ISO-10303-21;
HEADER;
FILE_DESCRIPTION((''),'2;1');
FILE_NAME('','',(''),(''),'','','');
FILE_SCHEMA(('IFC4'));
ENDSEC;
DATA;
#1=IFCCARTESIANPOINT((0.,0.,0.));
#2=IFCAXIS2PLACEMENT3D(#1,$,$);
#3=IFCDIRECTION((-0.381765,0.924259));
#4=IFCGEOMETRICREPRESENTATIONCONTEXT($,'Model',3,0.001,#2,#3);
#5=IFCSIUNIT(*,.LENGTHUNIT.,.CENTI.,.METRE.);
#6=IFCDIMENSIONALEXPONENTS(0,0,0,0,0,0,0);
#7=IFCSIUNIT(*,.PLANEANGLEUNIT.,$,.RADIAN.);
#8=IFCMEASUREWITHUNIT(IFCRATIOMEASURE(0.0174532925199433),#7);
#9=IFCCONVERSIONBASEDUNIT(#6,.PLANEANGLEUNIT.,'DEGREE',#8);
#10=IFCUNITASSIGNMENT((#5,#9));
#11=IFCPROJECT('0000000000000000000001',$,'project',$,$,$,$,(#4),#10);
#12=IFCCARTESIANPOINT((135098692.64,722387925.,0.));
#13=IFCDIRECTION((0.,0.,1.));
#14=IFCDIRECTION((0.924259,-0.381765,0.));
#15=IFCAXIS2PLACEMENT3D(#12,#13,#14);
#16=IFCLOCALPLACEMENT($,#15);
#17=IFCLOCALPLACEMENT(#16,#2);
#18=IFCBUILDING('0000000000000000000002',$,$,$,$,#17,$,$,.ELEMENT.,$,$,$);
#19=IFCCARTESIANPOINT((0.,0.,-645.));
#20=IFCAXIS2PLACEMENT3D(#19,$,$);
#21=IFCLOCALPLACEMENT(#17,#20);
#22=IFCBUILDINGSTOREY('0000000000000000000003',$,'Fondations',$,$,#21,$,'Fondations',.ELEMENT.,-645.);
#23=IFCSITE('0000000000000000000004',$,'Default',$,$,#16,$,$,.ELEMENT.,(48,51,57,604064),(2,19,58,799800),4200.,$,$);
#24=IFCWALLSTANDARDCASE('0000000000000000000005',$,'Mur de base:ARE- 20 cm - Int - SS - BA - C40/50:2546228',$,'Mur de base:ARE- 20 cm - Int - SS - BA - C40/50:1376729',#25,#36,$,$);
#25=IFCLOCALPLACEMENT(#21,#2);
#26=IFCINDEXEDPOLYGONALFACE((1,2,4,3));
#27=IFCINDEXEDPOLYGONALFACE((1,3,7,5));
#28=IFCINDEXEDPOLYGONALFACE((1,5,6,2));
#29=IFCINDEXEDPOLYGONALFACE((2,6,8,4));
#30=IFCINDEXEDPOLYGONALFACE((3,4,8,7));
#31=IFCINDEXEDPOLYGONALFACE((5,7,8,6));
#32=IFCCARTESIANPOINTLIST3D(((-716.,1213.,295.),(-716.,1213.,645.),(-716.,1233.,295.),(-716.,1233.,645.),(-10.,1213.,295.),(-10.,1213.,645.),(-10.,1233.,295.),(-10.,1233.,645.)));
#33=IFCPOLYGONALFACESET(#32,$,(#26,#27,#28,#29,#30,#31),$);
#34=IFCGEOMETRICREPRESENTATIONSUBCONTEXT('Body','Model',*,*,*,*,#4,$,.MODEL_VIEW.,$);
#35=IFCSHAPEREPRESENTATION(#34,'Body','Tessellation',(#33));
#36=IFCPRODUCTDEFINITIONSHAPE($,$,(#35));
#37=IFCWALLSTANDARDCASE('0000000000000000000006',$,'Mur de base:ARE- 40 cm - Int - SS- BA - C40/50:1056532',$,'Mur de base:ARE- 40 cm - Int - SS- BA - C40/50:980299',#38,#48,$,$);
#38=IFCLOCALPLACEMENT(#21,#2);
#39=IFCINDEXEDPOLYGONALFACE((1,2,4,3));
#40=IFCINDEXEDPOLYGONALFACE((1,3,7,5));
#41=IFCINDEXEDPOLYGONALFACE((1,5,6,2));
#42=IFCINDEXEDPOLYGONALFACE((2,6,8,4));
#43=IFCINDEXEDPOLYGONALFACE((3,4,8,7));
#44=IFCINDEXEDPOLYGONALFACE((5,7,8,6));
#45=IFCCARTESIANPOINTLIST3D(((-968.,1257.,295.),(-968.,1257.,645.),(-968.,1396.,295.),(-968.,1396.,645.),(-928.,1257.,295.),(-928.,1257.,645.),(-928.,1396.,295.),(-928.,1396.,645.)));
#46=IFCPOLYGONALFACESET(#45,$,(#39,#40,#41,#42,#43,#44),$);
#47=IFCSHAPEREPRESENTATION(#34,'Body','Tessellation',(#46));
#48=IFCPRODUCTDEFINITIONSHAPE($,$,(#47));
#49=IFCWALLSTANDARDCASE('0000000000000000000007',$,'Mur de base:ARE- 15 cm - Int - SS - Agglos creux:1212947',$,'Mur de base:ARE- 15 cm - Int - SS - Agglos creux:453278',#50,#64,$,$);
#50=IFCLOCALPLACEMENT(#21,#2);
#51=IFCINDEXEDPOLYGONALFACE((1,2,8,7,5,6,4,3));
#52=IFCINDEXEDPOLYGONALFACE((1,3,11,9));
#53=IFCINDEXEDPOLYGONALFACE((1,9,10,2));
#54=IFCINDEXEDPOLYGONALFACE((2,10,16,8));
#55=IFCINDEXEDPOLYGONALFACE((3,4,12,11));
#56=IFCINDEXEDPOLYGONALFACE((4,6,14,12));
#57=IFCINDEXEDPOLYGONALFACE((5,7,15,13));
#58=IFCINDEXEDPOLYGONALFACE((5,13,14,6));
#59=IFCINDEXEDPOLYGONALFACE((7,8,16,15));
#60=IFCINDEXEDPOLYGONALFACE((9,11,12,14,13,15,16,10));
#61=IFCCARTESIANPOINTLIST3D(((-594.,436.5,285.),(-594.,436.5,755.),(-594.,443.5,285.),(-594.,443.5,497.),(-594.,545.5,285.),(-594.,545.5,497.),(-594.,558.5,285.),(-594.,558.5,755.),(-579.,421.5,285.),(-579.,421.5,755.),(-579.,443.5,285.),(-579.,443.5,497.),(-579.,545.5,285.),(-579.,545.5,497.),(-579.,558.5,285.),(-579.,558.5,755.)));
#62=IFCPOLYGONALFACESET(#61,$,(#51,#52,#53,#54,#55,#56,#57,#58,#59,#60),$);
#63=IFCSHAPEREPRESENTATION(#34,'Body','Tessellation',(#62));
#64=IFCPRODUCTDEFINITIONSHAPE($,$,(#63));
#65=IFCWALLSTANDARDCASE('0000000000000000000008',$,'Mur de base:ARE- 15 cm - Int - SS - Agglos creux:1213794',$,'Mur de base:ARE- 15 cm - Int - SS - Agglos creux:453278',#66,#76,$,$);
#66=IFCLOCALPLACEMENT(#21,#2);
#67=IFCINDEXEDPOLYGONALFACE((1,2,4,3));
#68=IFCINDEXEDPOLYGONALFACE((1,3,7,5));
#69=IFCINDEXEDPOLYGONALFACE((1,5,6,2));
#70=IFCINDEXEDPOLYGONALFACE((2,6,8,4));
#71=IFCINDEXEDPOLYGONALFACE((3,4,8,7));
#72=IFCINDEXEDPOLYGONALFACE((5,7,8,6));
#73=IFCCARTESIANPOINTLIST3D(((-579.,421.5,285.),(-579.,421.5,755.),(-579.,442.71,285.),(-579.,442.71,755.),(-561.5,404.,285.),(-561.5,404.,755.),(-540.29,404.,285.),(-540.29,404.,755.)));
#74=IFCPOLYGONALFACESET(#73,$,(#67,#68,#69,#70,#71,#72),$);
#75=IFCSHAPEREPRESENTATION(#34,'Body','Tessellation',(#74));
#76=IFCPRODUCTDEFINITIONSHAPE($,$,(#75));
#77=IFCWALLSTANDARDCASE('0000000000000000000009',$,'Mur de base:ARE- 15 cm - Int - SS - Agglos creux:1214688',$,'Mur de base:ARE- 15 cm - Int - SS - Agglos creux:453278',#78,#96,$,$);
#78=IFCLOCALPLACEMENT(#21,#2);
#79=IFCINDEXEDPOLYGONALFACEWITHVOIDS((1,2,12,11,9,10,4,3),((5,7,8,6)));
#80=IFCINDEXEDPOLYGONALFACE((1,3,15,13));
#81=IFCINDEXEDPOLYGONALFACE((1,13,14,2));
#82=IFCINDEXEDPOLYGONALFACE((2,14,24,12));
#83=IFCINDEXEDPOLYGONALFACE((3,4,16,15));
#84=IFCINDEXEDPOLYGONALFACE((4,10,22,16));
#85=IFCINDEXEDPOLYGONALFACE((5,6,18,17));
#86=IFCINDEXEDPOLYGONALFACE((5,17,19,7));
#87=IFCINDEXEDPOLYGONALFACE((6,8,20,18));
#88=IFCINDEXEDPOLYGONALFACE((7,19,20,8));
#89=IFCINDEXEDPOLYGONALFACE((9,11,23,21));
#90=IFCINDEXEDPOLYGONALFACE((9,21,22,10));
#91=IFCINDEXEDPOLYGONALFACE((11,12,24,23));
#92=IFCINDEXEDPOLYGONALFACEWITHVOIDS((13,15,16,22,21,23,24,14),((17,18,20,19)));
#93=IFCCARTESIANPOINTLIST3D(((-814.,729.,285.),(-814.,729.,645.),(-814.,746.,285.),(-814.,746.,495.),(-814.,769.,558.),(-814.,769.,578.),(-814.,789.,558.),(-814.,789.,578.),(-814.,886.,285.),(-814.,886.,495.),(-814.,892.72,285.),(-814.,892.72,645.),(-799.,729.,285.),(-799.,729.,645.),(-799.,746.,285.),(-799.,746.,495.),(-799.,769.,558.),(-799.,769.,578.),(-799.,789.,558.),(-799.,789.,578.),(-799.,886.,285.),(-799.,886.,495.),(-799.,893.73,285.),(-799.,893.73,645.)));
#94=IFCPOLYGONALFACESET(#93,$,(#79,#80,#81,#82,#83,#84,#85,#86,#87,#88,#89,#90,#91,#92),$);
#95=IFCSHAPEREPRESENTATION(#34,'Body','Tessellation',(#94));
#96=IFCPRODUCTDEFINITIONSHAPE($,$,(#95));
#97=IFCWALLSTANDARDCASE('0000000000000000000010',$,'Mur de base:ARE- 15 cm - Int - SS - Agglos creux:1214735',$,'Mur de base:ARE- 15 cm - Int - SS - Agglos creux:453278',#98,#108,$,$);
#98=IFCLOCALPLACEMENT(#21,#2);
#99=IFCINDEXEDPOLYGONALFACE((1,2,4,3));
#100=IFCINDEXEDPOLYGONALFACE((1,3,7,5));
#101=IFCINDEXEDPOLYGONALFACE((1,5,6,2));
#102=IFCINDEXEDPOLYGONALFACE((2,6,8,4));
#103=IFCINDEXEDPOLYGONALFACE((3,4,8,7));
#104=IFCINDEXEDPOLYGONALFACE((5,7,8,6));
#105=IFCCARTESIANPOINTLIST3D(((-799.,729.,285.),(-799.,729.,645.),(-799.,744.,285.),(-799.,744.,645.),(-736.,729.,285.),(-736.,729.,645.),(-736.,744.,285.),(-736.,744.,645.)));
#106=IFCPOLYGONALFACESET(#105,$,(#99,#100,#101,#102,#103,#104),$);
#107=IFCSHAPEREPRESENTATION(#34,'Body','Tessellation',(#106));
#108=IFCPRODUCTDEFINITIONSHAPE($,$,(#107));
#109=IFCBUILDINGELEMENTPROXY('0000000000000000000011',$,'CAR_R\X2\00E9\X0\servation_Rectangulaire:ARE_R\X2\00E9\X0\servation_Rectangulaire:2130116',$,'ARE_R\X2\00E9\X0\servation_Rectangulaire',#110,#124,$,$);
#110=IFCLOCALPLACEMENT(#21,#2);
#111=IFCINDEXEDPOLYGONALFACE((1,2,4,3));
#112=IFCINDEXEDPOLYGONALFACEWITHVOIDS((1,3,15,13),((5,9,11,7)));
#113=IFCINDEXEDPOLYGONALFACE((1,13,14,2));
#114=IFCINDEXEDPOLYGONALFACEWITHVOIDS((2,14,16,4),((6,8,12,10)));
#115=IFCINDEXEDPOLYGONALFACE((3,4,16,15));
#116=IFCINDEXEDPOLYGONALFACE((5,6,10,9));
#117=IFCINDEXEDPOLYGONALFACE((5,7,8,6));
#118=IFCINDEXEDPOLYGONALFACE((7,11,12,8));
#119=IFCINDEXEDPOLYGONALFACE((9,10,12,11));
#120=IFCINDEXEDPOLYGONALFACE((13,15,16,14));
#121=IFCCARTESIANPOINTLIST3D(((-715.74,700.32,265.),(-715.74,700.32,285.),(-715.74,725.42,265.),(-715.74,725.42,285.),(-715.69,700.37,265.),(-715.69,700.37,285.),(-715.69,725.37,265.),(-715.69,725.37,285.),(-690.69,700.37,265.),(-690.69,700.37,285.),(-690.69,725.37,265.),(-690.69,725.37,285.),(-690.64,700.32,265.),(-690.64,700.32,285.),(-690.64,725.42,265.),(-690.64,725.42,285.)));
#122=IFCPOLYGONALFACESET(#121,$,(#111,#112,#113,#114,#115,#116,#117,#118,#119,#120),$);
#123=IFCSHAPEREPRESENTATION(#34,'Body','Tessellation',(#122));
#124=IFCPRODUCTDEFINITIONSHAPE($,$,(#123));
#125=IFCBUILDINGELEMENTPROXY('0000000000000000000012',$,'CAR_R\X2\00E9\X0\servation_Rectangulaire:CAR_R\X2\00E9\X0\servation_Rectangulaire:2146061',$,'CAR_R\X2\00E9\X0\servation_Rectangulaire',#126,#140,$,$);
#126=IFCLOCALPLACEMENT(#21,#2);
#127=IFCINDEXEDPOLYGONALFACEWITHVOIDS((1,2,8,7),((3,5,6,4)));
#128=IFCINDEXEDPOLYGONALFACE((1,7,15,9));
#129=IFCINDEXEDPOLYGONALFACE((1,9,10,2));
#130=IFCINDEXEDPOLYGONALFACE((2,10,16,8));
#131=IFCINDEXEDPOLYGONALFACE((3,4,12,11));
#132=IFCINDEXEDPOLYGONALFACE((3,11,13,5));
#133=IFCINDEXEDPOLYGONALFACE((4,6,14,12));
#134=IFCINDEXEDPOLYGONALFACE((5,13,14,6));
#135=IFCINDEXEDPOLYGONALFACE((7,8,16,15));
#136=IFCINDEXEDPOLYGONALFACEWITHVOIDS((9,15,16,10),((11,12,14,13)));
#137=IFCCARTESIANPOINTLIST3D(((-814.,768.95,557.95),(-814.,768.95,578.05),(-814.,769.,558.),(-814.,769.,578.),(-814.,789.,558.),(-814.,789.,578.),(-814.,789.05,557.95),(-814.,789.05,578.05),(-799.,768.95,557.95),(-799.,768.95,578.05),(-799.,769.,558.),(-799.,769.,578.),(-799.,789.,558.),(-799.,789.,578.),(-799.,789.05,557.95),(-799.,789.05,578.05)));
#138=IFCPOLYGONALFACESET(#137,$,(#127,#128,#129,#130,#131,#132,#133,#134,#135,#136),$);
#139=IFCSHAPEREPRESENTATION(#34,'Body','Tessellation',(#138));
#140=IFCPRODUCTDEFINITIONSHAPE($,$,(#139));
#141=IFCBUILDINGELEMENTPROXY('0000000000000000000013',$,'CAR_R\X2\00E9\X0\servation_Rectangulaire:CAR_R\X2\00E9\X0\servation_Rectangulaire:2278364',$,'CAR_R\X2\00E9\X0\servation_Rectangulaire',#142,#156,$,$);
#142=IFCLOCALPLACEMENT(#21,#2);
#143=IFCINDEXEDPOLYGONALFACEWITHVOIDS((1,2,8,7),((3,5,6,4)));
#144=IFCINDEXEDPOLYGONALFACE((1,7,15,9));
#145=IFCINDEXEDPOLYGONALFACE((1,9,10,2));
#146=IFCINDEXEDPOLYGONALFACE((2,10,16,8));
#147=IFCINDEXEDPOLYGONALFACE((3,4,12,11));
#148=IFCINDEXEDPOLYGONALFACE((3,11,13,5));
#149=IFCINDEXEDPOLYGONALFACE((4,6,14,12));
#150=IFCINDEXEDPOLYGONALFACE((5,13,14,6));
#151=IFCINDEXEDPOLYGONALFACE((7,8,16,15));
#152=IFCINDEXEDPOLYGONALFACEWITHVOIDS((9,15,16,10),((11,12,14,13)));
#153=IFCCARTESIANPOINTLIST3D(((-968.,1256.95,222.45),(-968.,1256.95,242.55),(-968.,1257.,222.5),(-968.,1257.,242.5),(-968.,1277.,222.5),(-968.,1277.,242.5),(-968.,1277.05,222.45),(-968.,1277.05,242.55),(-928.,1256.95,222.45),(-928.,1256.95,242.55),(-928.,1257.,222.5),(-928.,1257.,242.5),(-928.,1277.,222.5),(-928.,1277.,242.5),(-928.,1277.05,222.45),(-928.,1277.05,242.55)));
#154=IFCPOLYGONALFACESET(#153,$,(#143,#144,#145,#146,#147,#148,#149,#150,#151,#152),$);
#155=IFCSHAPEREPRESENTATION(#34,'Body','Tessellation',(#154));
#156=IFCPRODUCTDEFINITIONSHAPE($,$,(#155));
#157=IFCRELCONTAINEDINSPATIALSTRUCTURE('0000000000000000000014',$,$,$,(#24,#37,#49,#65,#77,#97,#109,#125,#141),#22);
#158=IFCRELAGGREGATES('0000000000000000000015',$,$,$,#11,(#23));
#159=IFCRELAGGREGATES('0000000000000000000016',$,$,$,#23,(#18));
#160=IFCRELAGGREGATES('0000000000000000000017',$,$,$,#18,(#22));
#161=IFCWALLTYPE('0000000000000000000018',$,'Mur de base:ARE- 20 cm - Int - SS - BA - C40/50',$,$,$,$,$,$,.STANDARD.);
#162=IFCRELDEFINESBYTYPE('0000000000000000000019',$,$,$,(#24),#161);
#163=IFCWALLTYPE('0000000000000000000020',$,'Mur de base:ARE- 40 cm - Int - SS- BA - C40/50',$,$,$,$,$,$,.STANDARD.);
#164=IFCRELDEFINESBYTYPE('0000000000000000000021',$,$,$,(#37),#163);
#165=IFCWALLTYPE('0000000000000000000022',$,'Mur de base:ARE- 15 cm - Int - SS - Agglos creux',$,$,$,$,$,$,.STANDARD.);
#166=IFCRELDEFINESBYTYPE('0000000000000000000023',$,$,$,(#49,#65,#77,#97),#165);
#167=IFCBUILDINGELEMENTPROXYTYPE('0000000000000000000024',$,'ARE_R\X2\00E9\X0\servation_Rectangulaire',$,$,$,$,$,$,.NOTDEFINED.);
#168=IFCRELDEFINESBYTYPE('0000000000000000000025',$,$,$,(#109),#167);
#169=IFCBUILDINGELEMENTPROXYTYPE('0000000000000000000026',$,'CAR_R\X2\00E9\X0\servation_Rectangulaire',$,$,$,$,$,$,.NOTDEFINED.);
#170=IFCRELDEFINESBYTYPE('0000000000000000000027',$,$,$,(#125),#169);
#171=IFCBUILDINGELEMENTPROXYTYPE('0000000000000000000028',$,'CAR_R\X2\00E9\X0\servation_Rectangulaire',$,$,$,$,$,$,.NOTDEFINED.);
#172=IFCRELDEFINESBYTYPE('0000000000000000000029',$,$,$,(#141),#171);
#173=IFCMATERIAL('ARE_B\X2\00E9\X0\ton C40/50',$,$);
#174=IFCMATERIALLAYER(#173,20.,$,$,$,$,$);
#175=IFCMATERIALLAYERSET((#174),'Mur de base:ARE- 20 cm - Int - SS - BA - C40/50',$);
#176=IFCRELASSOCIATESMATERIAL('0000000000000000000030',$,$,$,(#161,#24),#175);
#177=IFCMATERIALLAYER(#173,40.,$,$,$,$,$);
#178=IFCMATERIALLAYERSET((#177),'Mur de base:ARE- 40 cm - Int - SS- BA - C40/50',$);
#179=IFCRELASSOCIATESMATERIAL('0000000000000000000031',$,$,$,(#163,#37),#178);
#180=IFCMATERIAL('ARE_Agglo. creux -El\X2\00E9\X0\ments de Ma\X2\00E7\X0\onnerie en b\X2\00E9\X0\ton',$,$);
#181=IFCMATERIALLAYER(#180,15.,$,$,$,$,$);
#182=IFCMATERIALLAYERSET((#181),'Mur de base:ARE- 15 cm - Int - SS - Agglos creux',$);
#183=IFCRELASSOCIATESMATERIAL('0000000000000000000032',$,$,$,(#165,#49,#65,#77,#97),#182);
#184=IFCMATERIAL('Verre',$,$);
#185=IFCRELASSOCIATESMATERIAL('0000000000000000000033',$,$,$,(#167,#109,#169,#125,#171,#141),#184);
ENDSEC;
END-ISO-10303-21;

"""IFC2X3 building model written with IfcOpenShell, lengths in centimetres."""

from ifc_helpers import new_model, entity, si_unit, converted_unit, direction, frame, frame_2d, origin, place, context, subcontext, project, spatial, polyline, rectangle, outline, extrude, source, transform, mapped, material, layer, layer_set, layer_usage, type_object, type_shapes, element, save


model = new_model("IFC2X3")

# Units and contexts
model_context = context("Model", 3, precision=0.001, world=origin(), true_north=direction((-0.381765, 0.924259)))
body_context = subcontext(model_context, "Body", "Model", "MODEL_VIEW")
ifc_project = project(units=[si_unit("LENGTHUNIT", "METRE", prefix="CENTI"), converted_unit("PLANEANGLEUNIT", "DEGREE", entity("IfcRatioMeasure", 0.0174532925199433), si_unit("PLANEANGLEUNIT", "RADIAN"), dimensions=[0, 0, 0, 0, 0, 0, 0])], contexts=[model_context])

# Site, building, storey
site_placement = place(None, frame((135098692.64, 722387925.0, 0.0), z_axis=(0.0, 0.0, 1.0), x_axis=(0.924259, -0.381765, 0.0)))
site = spatial("IfcSite", under=ifc_project, at=site_placement, Name="Default", CompositionType="ELEMENT", RefLatitude=(48, 51, 57, 604064), RefLongitude=(2, 19, 58, 799800), RefElevation=4200.0)
building_placement = place(site_placement, origin())
building = spatial("IfcBuilding", under=site, at=building_placement, CompositionType="ELEMENT")
storey_placement = place(building_placement, frame((0.0, 0.0, -645.0)))
storey = spatial("IfcBuildingStorey", under=building, at=storey_placement, Name="Fondations", LongName="Fondations", CompositionType="ELEMENT", Elevation=-645.0)

# Shared definitions
ifc_material_1 = material(Name="ARE_Béton C40/50")
ifc_layer_1 = layer(ifc_material_1, 20.0)
ifc_layer_set_1 = layer_set([ifc_layer_1], Name="Mur de base:ARE- 20 cm - Int - SS - BA - C40/50")
wall_type_1 = type_object("IfcWallType", Name="Mur de base:ARE- 20 cm - Int - SS - BA - C40/50", PredefinedType="STANDARD", material=ifc_layer_set_1)

# Wall
ifc_layer_usage_1 = layer_usage(ifc_layer_set_1, "AXIS2", "NEGATIVE", 10.0)
wall_1_placement = place(storey_placement, frame((-716.0, 1223.0, 295.0)))
element("IfcWallStandardCase", 1, at=wall_1_placement, inside=storey, type_object=wall_type_1, material=ifc_layer_usage_1, Name="Mur de base:ARE- 20 cm - Int - SS - BA - C40/50:2546228", ObjectType="Mur de base:ARE- 20 cm - Int - SS - BA - C40/50:1376729", context=body_context, shape_type="SweptSolid", body=[
    extrude(rectangle(XDim=706.0, YDim=20.0, at=frame_2d((353.0, 0.0), x_axis=(-1.0, 0.0))), origin(), (0.0, 0.0, 1.0), 350.0),
])

# Wall
ifc_layer_2 = layer(ifc_material_1, 40.0)
ifc_layer_set_2 = layer_set([ifc_layer_2], Name="Mur de base:ARE- 40 cm - Int - SS- BA - C40/50")
ifc_layer_usage_2 = layer_usage(ifc_layer_set_2, "AXIS2", "NEGATIVE", 20.0)
wall_type_2 = type_object("IfcWallType", Name="Mur de base:ARE- 40 cm - Int - SS- BA - C40/50", PredefinedType="STANDARD", material=ifc_layer_set_2)
wall_2_placement = place(storey_placement, frame((-948.0, 1257.0, 295.0), z_axis=(0.0, 0.0, 1.0), x_axis=(0.0, 1.0, 0.0)))
element("IfcWallStandardCase", 2, at=wall_2_placement, inside=storey, type_object=wall_type_2, material=ifc_layer_usage_2, Name="Mur de base:ARE- 40 cm - Int - SS- BA - C40/50:1056532", ObjectType="Mur de base:ARE- 40 cm - Int - SS- BA - C40/50:980299", context=body_context, shape_type="SweptSolid", body=[
    extrude(rectangle(XDim=139.0, YDim=40.0, at=frame_2d((69.5, 0.0), x_axis=(-1.0, 0.0))), origin(), (0.0, 0.0, 1.0), 350.0),
])

# Wall, opening
ifc_material_2 = material(Name="ARE_Agglo. creux -Eléments de Maçonnerie en béton")
ifc_layer_3 = layer(ifc_material_2, 15.0)
ifc_layer_set_3 = layer_set([ifc_layer_3], Name="Mur de base:ARE- 15 cm - Int - SS - Agglos creux")
ifc_layer_usage_3 = layer_usage(ifc_layer_set_3, "AXIS2", "NEGATIVE", 7.5)
wall_type_3 = type_object("IfcWallType", Name="Mur de base:ARE- 15 cm - Int - SS - Agglos creux", PredefinedType="STANDARD", material=ifc_layer_set_3)
wall_3_placement = place(storey_placement, frame((-586.5, 558.5, 285.0), z_axis=(0.0, 0.0, 1.0), x_axis=(0.0, -1.0, 0.0)))
wall_3 = element("IfcWallStandardCase", 3, at=wall_3_placement, inside=storey, type_object=wall_type_3, material=ifc_layer_usage_3, Name="Mur de base:ARE- 15 cm - Int - SS - Agglos creux:1212947", ObjectType="Mur de base:ARE- 15 cm - Int - SS - Agglos creux:453278", context=body_context, shape_type="SweptSolid", body=[
    extrude(outline(polyline([(0.0, -7.5), (122.0, -7.5), (137.0, 7.5), (115.79, 7.5), (0.0, 7.5), (0.0, -7.5)])), origin(), (0.0, 0.0, 1.0), 470.0),
])
opening_1_placement = place(wall_3_placement, frame((558.5, 586.5, -285.0), z_axis=(0.0, 0.0, 1.0), x_axis=(0.0, 1.0, 0.0)))
element("IfcOpeningElement", 4, at=opening_1_placement, cuts=wall_3, ObjectType="Opening", context=body_context, shape_type="SweptSolid", body=[
    extrude(rectangle(XDim=212.0, YDim=102.0, at=frame_2d((0.0, 0.0), x_axis=(0.0, 1.0))), frame((-746.4, 494.5, 391.0), z_axis=(1.0, 0.0, 0.0), x_axis=(0.0, -1.0, 0.0)), (0.0, 0.0, 1.0), 304.8),
])

# Wall
ifc_layer_usage_4 = layer_usage(ifc_layer_set_3, "AXIS2", "NEGATIVE", 7.5)
wall_4_placement = place(storey_placement, frame((-584.3, 437.41, 285.0), z_axis=(0.0, 0.0, 1.0), x_axis=(0.707107, -0.707107, 0.0)))
element("IfcWallStandardCase", 5, at=wall_4_placement, inside=storey, type_object=wall_type_3, material=ifc_layer_usage_4, Name="Mur de base:ARE- 15 cm - Int - SS - Agglos creux:1213794", ObjectType="Mur de base:ARE- 15 cm - Int - SS - Agglos creux:453278", context=body_context, shape_type="SweptSolid", body=[
    extrude(outline(polyline([(39.75, -7.5), (54.75, 7.5), (0.0, 7.5), (15.0, -7.5), (39.75, -7.5)])), origin(), (0.0, 0.0, 1.0), 470.0),
])

# Wall, openings
ifc_layer_usage_5 = layer_usage(ifc_layer_set_3, "AXIS2", "NEGATIVE", 7.5)
wall_5_placement = place(storey_placement, frame((-806.5, 893.73, 285.0), z_axis=(0.0, 0.0, 1.0), x_axis=(0.0, -1.0, 0.0)))
wall_5 = element("IfcWallStandardCase", 6, at=wall_5_placement, inside=storey, type_object=wall_type_3, material=ifc_layer_usage_5, Name="Mur de base:ARE- 15 cm - Int - SS - Agglos creux:1214688", ObjectType="Mur de base:ARE- 15 cm - Int - SS - Agglos creux:453278", context=body_context, shape_type="SweptSolid", body=[
    extrude(outline(polyline([(1.01, -7.5), (164.73, -7.5), (164.73, 7.5), (149.73, 7.5), (0.0, 7.5), (1.01, -7.5)])), origin(), (0.0, 0.0, 1.0), 360.0),
])
opening_2_placement = place(wall_5_placement, origin())
element("IfcOpeningElement", 7, at=opening_2_placement, cuts=wall_5, ObjectType="Opening", context=body_context, shape_type="SweptSolid", body=[
    extrude(rectangle(XDim=20.0, YDim=20.0, at=frame_2d((0.0, 0.0), x_axis=(0.0, 1.0))), frame((114.73, -7.5, 283.0), z_axis=(0.0, 1.0, 0.0), x_axis=(1.0, 0.0, 0.0)), (0.0, 0.0, 1.0), 15.0),
])
opening_3_placement = place(wall_5_placement, frame((893.73, 806.5, -285.0), z_axis=(0.0, 0.0, 1.0), x_axis=(0.0, 1.0, 0.0)))
element("IfcOpeningElement", 8, at=opening_3_placement, cuts=wall_5, ObjectType="Opening", context=body_context, shape_type="SweptSolid", body=[
    extrude(rectangle(XDim=210.0, YDim=140.0, at=frame_2d((0.0, 0.0), x_axis=(0.0, 1.0))), frame((-966.4, 816.0, 390.0), z_axis=(1.0, 0.0, 0.0), x_axis=(0.0, -1.0, 0.0)), (0.0, 0.0, 1.0), 304.8),
])

# Wall
ifc_layer_usage_6 = layer_usage(ifc_layer_set_3, "AXIS2", "NEGATIVE", 7.5)
wall_6_placement = place(storey_placement, frame((-799.0, 736.5, 285.0)))
element("IfcWallStandardCase", 9, at=wall_6_placement, inside=storey, type_object=wall_type_3, material=ifc_layer_usage_6, Name="Mur de base:ARE- 15 cm - Int - SS - Agglos creux:1214735", ObjectType="Mur de base:ARE- 15 cm - Int - SS - Agglos creux:453278", context=body_context, shape_type="SweptSolid", body=[
    extrude(rectangle(XDim=63.0, YDim=15.0, at=frame_2d((31.5, 0.0), x_axis=(-1.0, 0.0))), origin(), (0.0, 0.0, 1.0), 360.0),
])

# Building element proxies
ifc_material_3 = material(Name="Verre")
building_element_proxy_type_1 = type_object("IfcBuildingElementProxyType", Name="ARE_Réservation_Rectangulaire", PredefinedType="NOTDEFINED", material=ifc_material_3)
shared_shape_1 = source(origin(), body_context, "Body", "SweptSolid", [
    extrude(outline(polyline([(-12.55, -12.55), (12.55, -12.55), (12.55, 12.55), (-12.55, 12.55), (-12.55, -12.55)]), holes=[polyline([(12.5, -12.5), (-12.5, -12.5), (-12.5, 12.5), (12.5, 12.5), (12.5, -12.5)])]), frame((0.0, 0.0, -20.0), z_axis=(0.0, 0.0, 1.0), x_axis=(-1.0, 0.0, 0.0)), (0.0, 0.0, 1.0), 20.0),
])
type_shapes(building_element_proxy_type_1, [shared_shape_1])
proxy_1_placement = place(storey_placement, frame((-703.19, 712.87, 285.0)))
element("IfcBuildingElementProxy", 10, at=proxy_1_placement, inside=storey, type_object=building_element_proxy_type_1, material=ifc_material_3, Name="CAR_Réservation_Rectangulaire:ARE_Réservation_Rectangulaire:2130116", ObjectType="ARE_Réservation_Rectangulaire", context=body_context, shape_type="MappedRepresentation", body=[
    mapped(shared_shape_1, transform((0.0, 0.0, 0.0), scale=1.0)),
])
building_element_proxy_type_2 = type_object("IfcBuildingElementProxyType", Name="CAR_Réservation_Rectangulaire", PredefinedType="NOTDEFINED", material=ifc_material_3)
shared_shape_2 = source(origin(), body_context, "Body", "SweptSolid", [
    extrude(outline(polyline([(-10.05, -10.05), (10.05, -10.05), (10.05, 10.05), (-10.05, 10.05), (-10.05, -10.05)]), holes=[polyline([(10.0, -10.0), (-10.0, -10.0), (-10.0, 10.0), (10.0, 10.0), (10.0, -10.0)])]), frame((0.0, 0.0, -7.5), z_axis=(0.0, 0.0, 1.0), x_axis=(-1.0, 0.0, 0.0)), (0.0, 0.0, 1.0), 15.0),
])
type_shapes(building_element_proxy_type_2, [shared_shape_2])
proxy_2_placement = place(storey_placement, frame((-806.5, 779.0, 568.0), z_axis=(1.0, 0.0, 0.0), x_axis=(0.0, 1.0, 0.0)))
element("IfcBuildingElementProxy", 11, at=proxy_2_placement, inside=storey, type_object=building_element_proxy_type_2, material=ifc_material_3, Name="CAR_Réservation_Rectangulaire:CAR_Réservation_Rectangulaire:2146061", ObjectType="CAR_Réservation_Rectangulaire", context=body_context, shape_type="MappedRepresentation", body=[
    mapped(shared_shape_2, transform((0.0, 0.0, 0.0), scale=1.0)),
])
building_element_proxy_type_3 = type_object("IfcBuildingElementProxyType", Name="CAR_Réservation_Rectangulaire", PredefinedType="NOTDEFINED", material=ifc_material_3)
shared_shape_3 = source(origin(), body_context, "Body", "SweptSolid", [
    extrude(outline(polyline([(-10.05, -10.05), (10.05, -10.05), (10.05, 10.05), (-10.05, 10.05), (-10.05, -10.05)]), holes=[polyline([(10.0, -10.0), (-10.0, -10.0), (-10.0, 10.0), (10.0, 10.0), (10.0, -10.0)])]), frame((0.0, 0.0, -40.0), z_axis=(0.0, 0.0, 1.0), x_axis=(-1.0, 0.0, 0.0)), (0.0, 0.0, 1.0), 40.0),
])
type_shapes(building_element_proxy_type_3, [shared_shape_3])
proxy_3_placement = place(storey_placement, frame((-928.0, 1267.0, 232.5), z_axis=(1.0, 0.0, 0.0), x_axis=(0.0, 1.0, 0.0)))
element("IfcBuildingElementProxy", 12, at=proxy_3_placement, inside=storey, type_object=building_element_proxy_type_3, material=ifc_material_3, Name="CAR_Réservation_Rectangulaire:CAR_Réservation_Rectangulaire:2278364", ObjectType="CAR_Réservation_Rectangulaire", context=body_context, shape_type="MappedRepresentation", body=[
    mapped(shared_shape_3, transform((0.0, 0.0, 0.0), scale=1.0)),
])

save(model, "model.ifc")
